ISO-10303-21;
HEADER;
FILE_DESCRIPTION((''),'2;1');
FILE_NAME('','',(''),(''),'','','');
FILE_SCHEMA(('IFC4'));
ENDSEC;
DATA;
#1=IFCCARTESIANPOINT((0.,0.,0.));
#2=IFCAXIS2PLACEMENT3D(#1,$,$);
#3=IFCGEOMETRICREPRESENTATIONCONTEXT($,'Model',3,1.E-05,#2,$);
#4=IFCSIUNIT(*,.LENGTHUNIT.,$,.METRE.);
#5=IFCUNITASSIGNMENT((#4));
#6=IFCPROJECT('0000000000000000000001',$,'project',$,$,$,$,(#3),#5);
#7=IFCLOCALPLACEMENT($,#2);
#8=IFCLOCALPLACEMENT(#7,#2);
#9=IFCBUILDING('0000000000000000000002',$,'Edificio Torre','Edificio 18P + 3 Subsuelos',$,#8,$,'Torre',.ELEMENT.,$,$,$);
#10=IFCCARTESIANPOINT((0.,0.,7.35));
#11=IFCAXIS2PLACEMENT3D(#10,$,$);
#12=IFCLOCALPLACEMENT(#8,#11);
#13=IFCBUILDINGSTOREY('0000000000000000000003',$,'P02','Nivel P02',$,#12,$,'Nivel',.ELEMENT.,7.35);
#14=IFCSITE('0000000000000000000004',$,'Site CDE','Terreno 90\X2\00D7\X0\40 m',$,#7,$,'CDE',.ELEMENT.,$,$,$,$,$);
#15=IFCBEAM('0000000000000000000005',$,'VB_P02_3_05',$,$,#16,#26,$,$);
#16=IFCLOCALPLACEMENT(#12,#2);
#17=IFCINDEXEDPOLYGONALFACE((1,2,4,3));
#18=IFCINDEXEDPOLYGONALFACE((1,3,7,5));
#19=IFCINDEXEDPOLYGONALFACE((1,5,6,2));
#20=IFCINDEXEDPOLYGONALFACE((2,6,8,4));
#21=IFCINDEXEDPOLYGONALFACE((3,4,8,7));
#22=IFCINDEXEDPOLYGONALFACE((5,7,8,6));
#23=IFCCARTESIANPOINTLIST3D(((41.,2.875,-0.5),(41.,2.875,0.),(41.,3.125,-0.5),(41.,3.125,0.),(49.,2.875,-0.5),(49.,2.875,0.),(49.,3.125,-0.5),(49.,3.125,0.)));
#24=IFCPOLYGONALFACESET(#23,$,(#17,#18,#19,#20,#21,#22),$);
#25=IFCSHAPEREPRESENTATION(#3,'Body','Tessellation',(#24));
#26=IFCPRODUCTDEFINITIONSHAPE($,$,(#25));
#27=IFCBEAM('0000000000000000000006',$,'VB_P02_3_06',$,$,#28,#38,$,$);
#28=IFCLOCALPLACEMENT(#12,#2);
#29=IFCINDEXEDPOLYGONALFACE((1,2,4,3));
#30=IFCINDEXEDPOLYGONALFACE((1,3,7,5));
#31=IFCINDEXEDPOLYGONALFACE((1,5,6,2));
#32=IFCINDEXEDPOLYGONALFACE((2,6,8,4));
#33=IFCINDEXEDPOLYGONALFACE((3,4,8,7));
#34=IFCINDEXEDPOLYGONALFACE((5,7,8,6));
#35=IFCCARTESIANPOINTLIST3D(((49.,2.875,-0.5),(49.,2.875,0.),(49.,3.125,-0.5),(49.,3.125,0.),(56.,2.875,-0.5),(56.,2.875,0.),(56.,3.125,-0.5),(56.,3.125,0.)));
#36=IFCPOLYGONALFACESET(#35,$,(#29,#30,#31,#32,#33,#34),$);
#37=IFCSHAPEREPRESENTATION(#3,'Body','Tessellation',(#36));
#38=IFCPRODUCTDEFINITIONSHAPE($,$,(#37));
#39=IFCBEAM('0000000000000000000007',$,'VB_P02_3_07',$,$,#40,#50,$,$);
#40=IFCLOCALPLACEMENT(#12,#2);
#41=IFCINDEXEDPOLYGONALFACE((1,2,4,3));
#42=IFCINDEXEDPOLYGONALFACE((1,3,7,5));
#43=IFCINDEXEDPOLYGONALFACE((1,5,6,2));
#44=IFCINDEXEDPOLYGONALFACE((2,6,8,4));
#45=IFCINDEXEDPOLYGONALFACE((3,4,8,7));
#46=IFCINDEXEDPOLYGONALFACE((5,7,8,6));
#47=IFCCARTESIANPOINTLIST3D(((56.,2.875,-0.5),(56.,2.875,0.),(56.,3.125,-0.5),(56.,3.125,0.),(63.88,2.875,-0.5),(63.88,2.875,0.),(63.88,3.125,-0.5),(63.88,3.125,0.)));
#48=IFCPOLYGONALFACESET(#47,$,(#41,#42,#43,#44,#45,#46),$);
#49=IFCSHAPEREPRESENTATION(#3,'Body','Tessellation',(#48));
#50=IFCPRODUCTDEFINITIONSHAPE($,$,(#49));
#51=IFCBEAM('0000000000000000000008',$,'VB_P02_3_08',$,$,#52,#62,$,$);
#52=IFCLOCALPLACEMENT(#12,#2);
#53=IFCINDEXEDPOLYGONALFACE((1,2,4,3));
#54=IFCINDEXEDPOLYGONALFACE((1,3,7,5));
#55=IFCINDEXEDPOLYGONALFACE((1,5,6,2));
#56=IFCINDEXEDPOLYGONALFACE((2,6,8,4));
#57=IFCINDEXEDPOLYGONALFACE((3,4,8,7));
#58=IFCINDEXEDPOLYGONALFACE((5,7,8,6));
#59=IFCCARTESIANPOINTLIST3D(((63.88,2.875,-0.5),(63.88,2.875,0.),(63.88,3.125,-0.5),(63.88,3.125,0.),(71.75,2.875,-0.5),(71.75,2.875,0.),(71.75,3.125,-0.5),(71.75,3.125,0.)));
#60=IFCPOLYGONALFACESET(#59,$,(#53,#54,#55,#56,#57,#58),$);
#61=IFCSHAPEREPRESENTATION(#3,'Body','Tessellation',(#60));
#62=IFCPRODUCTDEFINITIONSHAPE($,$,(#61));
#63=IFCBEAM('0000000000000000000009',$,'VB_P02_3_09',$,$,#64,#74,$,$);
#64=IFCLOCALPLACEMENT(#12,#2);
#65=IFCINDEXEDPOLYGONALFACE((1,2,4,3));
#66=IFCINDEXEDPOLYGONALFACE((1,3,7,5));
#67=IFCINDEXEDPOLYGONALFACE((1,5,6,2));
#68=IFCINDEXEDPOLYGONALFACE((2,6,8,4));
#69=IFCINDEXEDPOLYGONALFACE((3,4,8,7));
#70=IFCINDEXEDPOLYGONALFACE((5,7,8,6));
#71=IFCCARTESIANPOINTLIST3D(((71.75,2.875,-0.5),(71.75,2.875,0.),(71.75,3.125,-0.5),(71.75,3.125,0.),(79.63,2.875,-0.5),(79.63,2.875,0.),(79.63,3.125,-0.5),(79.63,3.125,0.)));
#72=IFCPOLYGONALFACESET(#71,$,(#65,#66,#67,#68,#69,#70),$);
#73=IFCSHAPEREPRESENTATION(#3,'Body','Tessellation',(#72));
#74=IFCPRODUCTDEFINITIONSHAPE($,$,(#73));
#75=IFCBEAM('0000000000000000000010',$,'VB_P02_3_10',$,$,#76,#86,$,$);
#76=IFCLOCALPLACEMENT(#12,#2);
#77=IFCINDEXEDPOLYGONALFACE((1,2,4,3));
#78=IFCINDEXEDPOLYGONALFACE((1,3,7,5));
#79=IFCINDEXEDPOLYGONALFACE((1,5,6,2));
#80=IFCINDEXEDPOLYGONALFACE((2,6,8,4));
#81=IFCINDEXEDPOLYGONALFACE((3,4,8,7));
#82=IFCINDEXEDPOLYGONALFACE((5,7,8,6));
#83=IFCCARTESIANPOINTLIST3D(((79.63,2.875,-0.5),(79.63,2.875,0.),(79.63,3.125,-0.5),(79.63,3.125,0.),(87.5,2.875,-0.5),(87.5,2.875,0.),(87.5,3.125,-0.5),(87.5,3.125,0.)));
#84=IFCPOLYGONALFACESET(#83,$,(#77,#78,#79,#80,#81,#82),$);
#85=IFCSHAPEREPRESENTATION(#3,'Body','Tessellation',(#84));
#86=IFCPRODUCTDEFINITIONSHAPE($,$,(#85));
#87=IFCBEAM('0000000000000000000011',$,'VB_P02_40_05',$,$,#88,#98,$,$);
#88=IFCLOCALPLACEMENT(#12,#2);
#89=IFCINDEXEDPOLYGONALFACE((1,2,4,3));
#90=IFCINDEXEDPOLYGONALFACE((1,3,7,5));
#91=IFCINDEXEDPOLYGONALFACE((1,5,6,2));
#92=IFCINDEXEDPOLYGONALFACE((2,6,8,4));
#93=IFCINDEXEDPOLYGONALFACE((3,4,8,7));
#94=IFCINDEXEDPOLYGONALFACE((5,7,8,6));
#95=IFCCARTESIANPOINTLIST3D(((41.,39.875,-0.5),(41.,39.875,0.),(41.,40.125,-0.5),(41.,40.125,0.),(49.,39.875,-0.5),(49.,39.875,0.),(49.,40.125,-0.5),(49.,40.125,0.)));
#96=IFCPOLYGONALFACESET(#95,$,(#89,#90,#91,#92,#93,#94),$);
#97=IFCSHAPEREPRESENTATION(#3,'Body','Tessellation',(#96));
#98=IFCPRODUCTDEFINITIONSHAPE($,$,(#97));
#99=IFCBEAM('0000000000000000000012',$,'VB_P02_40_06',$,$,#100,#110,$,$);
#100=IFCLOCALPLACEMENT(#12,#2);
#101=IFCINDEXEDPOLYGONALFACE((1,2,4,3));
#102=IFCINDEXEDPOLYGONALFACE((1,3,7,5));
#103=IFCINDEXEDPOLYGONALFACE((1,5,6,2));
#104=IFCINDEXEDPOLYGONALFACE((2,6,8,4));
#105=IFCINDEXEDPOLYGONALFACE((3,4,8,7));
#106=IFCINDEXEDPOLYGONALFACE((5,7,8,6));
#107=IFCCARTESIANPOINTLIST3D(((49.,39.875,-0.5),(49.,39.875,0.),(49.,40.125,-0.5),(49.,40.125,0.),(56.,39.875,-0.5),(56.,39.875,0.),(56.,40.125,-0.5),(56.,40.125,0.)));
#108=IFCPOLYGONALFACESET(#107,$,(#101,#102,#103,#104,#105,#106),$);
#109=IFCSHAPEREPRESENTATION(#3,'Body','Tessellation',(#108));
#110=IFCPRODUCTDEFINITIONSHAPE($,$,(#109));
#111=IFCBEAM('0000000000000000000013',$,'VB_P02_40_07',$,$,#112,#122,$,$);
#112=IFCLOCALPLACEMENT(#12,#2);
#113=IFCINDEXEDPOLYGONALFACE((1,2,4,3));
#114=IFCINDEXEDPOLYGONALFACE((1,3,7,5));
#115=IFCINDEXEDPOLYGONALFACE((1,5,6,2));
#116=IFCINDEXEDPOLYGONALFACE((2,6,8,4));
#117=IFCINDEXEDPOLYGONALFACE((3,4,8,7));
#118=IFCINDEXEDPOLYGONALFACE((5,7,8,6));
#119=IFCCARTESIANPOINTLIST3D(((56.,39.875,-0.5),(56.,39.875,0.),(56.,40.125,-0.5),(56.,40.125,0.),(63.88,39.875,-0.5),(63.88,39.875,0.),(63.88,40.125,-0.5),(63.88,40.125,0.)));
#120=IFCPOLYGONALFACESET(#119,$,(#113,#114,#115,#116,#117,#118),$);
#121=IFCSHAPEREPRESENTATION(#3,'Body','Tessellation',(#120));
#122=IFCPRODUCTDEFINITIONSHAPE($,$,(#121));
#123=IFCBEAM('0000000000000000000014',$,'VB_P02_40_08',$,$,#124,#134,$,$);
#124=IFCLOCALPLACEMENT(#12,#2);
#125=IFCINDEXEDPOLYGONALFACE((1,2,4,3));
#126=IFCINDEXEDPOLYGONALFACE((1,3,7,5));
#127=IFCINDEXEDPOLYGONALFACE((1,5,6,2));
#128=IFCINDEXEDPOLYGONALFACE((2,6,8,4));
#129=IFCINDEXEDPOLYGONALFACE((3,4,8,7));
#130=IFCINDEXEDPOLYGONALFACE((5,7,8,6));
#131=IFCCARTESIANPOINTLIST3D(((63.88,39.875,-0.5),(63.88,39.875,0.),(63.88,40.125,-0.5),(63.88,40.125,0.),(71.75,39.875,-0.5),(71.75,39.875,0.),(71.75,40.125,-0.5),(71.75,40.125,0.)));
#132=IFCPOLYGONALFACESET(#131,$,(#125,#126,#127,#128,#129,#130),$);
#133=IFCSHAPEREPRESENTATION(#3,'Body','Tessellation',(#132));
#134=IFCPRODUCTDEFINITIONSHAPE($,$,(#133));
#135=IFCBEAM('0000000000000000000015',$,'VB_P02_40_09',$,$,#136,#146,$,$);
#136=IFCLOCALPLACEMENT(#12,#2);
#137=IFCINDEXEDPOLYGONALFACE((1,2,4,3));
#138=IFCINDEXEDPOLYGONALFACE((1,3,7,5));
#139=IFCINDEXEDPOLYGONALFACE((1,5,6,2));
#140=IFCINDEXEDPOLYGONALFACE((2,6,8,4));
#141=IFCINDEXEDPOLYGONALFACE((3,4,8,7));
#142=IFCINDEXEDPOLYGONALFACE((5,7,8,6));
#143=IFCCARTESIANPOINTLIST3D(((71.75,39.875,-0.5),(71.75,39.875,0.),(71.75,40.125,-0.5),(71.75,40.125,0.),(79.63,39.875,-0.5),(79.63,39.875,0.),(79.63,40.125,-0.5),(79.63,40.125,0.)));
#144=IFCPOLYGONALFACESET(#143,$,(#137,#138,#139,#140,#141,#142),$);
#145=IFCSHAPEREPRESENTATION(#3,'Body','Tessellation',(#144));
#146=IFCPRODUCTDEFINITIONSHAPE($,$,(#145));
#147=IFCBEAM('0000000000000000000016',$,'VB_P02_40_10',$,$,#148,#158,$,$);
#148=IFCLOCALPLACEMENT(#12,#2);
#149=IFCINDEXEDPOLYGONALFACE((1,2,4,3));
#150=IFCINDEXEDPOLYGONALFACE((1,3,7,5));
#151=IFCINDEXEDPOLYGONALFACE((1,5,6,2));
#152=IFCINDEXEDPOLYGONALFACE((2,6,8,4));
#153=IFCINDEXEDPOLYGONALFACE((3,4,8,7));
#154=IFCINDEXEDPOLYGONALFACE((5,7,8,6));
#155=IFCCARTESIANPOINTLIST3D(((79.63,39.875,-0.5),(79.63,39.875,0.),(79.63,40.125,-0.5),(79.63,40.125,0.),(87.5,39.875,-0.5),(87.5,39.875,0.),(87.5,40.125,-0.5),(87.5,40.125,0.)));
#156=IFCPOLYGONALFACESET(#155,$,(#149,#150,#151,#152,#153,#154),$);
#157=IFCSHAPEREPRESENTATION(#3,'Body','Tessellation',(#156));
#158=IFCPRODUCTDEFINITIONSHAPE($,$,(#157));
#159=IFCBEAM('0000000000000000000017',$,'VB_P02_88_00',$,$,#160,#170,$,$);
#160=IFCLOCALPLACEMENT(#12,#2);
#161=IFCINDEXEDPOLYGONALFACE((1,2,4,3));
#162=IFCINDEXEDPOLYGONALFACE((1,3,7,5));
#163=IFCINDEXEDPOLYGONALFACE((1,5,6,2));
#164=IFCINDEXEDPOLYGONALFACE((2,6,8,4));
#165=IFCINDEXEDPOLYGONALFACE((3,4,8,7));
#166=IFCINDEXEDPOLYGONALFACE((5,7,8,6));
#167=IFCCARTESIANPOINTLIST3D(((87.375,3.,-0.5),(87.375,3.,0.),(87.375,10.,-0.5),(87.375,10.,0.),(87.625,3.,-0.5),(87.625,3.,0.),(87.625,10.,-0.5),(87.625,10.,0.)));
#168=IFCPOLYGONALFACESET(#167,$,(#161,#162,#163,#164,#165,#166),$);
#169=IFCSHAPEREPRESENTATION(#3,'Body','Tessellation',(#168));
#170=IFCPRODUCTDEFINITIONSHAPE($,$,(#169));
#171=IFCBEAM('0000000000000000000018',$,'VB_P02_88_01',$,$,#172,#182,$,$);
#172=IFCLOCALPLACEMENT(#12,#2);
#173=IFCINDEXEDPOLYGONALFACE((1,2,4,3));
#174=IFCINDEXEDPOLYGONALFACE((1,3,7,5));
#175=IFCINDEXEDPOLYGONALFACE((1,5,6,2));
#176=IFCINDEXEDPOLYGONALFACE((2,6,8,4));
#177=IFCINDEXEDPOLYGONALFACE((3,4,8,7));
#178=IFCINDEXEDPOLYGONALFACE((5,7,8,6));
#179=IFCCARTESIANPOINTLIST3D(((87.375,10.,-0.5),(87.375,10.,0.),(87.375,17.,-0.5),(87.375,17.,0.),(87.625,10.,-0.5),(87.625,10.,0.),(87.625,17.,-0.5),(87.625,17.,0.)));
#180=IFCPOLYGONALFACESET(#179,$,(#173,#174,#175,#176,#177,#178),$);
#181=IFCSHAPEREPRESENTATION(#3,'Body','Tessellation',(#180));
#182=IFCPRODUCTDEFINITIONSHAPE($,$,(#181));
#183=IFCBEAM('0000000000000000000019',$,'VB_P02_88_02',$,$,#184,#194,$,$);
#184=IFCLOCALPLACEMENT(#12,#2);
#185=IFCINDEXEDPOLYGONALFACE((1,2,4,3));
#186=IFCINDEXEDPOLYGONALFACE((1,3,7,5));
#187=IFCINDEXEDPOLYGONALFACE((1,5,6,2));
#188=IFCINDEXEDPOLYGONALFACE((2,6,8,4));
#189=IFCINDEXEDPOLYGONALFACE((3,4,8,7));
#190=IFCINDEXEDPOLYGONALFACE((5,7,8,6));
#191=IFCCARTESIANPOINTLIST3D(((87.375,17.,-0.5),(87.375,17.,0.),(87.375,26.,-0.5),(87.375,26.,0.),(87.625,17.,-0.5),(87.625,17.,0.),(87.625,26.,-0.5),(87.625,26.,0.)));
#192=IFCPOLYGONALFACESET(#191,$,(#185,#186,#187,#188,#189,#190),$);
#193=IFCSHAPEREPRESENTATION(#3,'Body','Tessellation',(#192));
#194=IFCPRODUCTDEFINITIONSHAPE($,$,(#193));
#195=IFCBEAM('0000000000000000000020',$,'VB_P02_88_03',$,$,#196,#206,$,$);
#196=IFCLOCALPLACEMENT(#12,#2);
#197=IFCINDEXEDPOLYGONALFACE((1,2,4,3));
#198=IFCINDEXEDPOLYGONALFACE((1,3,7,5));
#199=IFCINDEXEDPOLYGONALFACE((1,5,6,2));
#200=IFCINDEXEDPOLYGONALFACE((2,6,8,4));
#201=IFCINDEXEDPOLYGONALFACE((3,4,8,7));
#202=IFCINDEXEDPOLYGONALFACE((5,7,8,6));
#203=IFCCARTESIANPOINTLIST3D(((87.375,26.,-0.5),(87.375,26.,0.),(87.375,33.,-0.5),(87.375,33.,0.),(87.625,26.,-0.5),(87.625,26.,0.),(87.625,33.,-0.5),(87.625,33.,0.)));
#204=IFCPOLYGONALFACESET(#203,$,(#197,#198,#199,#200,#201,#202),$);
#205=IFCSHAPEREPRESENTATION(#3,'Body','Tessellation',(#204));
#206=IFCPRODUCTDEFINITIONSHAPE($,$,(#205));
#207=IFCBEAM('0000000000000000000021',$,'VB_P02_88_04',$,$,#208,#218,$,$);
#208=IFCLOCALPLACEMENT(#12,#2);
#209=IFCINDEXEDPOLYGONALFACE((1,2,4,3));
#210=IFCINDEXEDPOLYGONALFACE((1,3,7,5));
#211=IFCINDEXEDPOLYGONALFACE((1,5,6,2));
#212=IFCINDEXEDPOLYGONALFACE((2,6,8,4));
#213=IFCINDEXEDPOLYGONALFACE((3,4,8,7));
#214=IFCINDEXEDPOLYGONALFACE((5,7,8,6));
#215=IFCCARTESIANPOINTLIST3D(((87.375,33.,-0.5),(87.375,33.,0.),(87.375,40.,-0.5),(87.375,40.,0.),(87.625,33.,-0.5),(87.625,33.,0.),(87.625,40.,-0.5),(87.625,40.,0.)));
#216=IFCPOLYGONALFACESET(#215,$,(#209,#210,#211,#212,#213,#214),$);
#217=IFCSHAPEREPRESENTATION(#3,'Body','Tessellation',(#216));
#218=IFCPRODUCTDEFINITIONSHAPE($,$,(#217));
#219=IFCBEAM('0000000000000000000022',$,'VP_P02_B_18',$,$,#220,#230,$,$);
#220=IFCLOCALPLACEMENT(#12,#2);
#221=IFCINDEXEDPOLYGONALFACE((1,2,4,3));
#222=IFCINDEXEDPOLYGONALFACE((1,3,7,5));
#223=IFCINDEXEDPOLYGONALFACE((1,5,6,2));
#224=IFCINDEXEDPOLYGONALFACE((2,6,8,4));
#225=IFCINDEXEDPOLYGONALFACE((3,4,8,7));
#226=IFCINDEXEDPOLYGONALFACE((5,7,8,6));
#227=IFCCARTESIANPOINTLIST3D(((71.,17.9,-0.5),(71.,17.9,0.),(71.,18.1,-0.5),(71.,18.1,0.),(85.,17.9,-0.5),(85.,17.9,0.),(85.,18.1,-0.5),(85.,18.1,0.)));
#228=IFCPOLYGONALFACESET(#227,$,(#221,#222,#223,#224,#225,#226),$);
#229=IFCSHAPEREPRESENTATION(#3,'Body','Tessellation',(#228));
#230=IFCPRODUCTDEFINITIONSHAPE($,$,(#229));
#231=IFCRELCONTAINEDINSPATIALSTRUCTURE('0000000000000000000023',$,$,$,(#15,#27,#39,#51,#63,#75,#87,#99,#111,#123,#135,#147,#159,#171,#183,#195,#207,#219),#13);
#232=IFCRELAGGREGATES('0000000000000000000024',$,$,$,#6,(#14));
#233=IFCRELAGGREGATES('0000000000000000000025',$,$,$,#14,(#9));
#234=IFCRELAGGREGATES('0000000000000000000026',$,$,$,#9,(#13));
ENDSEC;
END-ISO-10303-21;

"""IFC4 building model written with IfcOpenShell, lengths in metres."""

from ifc_helpers import new_model, si_unit, frame, origin, origin_2d, place, context, project, spatial, rectangle, extrude, element, save


model = new_model("IFC4")

# Units and contexts
model_context = context("Model", 3, precision=1e-05, world=origin())
ifc_project = project(units=[si_unit("LENGTHUNIT", "METRE")], contexts=[model_context])

# Site, building, storey
site_placement = place(None, origin())
site = spatial("IfcSite", under=ifc_project, at=site_placement, Name="Site CDE", Description="Terreno 90×40 m", LongName="CDE", CompositionType="ELEMENT")
building_placement = place(site_placement, origin())
building = spatial("IfcBuilding", under=site, at=building_placement, Name="Edificio Torre", Description="Edificio 18P + 3 Subsuelos", LongName="Torre", CompositionType="ELEMENT")
storey_placement = place(building_placement, frame((0.0, 0.0, 7.35)))
storey = spatial("IfcBuildingStorey", under=building, at=storey_placement, Name="P02", Description="Nivel P02", LongName="Nivel", CompositionType="ELEMENT", Elevation=7.35)

# Beams
beam_1_placement = place(storey_placement, frame((45.0, 3.0, -0.5)))
element("IfcBeam", 1, at=beam_1_placement, inside=storey, Name="VB_P02_3_05", context=model_context, shape_type="SweptSolid", body=[
    extrude(rectangle(XDim=8.0, YDim=0.25, at=origin_2d()), origin(), (0.0, 0.0, 1.0), 0.5),
])
beam_2_placement = place(storey_placement, frame((52.5, 3.0, -0.5)))
element("IfcBeam", 2, at=beam_2_placement, inside=storey, Name="VB_P02_3_06", context=model_context, shape_type="SweptSolid", body=[
    extrude(rectangle(XDim=7.0, YDim=0.25, at=origin_2d()), origin(), (0.0, 0.0, 1.0), 0.5),
])
beam_3_placement = place(storey_placement, frame((59.94, 3.0, -0.5)))
element("IfcBeam", 3, at=beam_3_placement, inside=storey, Name="VB_P02_3_07", context=model_context, shape_type="SweptSolid", body=[
    extrude(rectangle(XDim=7.88, YDim=0.25, at=origin_2d()), origin(), (0.0, 0.0, 1.0), 0.5),
])
beam_4_placement = place(storey_placement, frame((67.815, 3.0, -0.5)))
element("IfcBeam", 4, at=beam_4_placement, inside=storey, Name="VB_P02_3_08", context=model_context, shape_type="SweptSolid", body=[
    extrude(rectangle(XDim=7.87, YDim=0.25, at=origin_2d()), origin(), (0.0, 0.0, 1.0), 0.5),
])
beam_5_placement = place(storey_placement, frame((75.69, 3.0, -0.5)))
element("IfcBeam", 5, at=beam_5_placement, inside=storey, Name="VB_P02_3_09", context=model_context, shape_type="SweptSolid", body=[
    extrude(rectangle(XDim=7.88, YDim=0.25, at=origin_2d()), origin(), (0.0, 0.0, 1.0), 0.5),
])
beam_6_placement = place(storey_placement, frame((83.565, 3.0, -0.5)))
element("IfcBeam", 6, at=beam_6_placement, inside=storey, Name="VB_P02_3_10", context=model_context, shape_type="SweptSolid", body=[
    extrude(rectangle(XDim=7.87, YDim=0.25, at=origin_2d()), origin(), (0.0, 0.0, 1.0), 0.5),
])
beam_7_placement = place(storey_placement, frame((45.0, 40.0, -0.5)))
element("IfcBeam", 7, at=beam_7_placement, inside=storey, Name="VB_P02_40_05", context=model_context, shape_type="SweptSolid", body=[
    extrude(rectangle(XDim=8.0, YDim=0.25, at=origin_2d()), origin(), (0.0, 0.0, 1.0), 0.5),
])
beam_8_placement = place(storey_placement, frame((52.5, 40.0, -0.5)))
element("IfcBeam", 8, at=beam_8_placement, inside=storey, Name="VB_P02_40_06", context=model_context, shape_type="SweptSolid", body=[
    extrude(rectangle(XDim=7.0, YDim=0.25, at=origin_2d()), origin(), (0.0, 0.0, 1.0), 0.5),
])
beam_9_placement = place(storey_placement, frame((59.94, 40.0, -0.5)))
element("IfcBeam", 9, at=beam_9_placement, inside=storey, Name="VB_P02_40_07", context=model_context, shape_type="SweptSolid", body=[
    extrude(rectangle(XDim=7.88, YDim=0.25, at=origin_2d()), origin(), (0.0, 0.0, 1.0), 0.5),
])
beam_10_placement = place(storey_placement, frame((67.815, 40.0, -0.5)))
element("IfcBeam", 10, at=beam_10_placement, inside=storey, Name="VB_P02_40_08", context=model_context, shape_type="SweptSolid", body=[
    extrude(rectangle(XDim=7.87, YDim=0.25, at=origin_2d()), origin(), (0.0, 0.0, 1.0), 0.5),
])
beam_11_placement = place(storey_placement, frame((75.69, 40.0, -0.5)))
element("IfcBeam", 11, at=beam_11_placement, inside=storey, Name="VB_P02_40_09", context=model_context, shape_type="SweptSolid", body=[
    extrude(rectangle(XDim=7.88, YDim=0.25, at=origin_2d()), origin(), (0.0, 0.0, 1.0), 0.5),
])
beam_12_placement = place(storey_placement, frame((83.565, 40.0, -0.5)))
element("IfcBeam", 12, at=beam_12_placement, inside=storey, Name="VB_P02_40_10", context=model_context, shape_type="SweptSolid", body=[
    extrude(rectangle(XDim=7.87, YDim=0.25, at=origin_2d()), origin(), (0.0, 0.0, 1.0), 0.5),
])
for number, where, name in (
    (13, (87.5, 6.5, -0.5), "VB_P02_88_00"),
    (14, (87.5, 13.5, -0.5), "VB_P02_88_01"),
):
    element("IfcBeam", number, at=place(storey_placement, frame(where)), inside=storey, Name=name, context=model_context, shape_type="SweptSolid", body=[
        extrude(rectangle(XDim=0.25, YDim=7.0, at=origin_2d()), origin(), (0.0, 0.0, 1.0), 0.5),
    ])
beam_13_placement = place(storey_placement, frame((87.5, 21.5, -0.5)))
element("IfcBeam", 15, at=beam_13_placement, inside=storey, Name="VB_P02_88_02", context=model_context, shape_type="SweptSolid", body=[
    extrude(rectangle(XDim=0.25, YDim=9.0, at=origin_2d()), origin(), (0.0, 0.0, 1.0), 0.5),
])
for number, where, name in (
    (16, (87.5, 29.5, -0.5), "VB_P02_88_03"),
    (17, (87.5, 36.5, -0.5), "VB_P02_88_04"),
):
    element("IfcBeam", number, at=place(storey_placement, frame(where)), inside=storey, Name=name, context=model_context, shape_type="SweptSolid", body=[
        extrude(rectangle(XDim=0.25, YDim=7.0, at=origin_2d()), origin(), (0.0, 0.0, 1.0), 0.5),
    ])
for number, where, name in (
    (18, (78.0, 18.0, -0.5), "VP_P02_B_18"),
):
    element("IfcBeam", number, at=place(storey_placement, frame(where)), inside=storey, Name=name, context=model_context, shape_type="SweptSolid", body=[
        extrude(rectangle(XDim=14.0, YDim=0.2, at=origin_2d()), origin(), (0.0, 0.0, 1.0), 0.5),
    ])

save(model, "model.ifc")
